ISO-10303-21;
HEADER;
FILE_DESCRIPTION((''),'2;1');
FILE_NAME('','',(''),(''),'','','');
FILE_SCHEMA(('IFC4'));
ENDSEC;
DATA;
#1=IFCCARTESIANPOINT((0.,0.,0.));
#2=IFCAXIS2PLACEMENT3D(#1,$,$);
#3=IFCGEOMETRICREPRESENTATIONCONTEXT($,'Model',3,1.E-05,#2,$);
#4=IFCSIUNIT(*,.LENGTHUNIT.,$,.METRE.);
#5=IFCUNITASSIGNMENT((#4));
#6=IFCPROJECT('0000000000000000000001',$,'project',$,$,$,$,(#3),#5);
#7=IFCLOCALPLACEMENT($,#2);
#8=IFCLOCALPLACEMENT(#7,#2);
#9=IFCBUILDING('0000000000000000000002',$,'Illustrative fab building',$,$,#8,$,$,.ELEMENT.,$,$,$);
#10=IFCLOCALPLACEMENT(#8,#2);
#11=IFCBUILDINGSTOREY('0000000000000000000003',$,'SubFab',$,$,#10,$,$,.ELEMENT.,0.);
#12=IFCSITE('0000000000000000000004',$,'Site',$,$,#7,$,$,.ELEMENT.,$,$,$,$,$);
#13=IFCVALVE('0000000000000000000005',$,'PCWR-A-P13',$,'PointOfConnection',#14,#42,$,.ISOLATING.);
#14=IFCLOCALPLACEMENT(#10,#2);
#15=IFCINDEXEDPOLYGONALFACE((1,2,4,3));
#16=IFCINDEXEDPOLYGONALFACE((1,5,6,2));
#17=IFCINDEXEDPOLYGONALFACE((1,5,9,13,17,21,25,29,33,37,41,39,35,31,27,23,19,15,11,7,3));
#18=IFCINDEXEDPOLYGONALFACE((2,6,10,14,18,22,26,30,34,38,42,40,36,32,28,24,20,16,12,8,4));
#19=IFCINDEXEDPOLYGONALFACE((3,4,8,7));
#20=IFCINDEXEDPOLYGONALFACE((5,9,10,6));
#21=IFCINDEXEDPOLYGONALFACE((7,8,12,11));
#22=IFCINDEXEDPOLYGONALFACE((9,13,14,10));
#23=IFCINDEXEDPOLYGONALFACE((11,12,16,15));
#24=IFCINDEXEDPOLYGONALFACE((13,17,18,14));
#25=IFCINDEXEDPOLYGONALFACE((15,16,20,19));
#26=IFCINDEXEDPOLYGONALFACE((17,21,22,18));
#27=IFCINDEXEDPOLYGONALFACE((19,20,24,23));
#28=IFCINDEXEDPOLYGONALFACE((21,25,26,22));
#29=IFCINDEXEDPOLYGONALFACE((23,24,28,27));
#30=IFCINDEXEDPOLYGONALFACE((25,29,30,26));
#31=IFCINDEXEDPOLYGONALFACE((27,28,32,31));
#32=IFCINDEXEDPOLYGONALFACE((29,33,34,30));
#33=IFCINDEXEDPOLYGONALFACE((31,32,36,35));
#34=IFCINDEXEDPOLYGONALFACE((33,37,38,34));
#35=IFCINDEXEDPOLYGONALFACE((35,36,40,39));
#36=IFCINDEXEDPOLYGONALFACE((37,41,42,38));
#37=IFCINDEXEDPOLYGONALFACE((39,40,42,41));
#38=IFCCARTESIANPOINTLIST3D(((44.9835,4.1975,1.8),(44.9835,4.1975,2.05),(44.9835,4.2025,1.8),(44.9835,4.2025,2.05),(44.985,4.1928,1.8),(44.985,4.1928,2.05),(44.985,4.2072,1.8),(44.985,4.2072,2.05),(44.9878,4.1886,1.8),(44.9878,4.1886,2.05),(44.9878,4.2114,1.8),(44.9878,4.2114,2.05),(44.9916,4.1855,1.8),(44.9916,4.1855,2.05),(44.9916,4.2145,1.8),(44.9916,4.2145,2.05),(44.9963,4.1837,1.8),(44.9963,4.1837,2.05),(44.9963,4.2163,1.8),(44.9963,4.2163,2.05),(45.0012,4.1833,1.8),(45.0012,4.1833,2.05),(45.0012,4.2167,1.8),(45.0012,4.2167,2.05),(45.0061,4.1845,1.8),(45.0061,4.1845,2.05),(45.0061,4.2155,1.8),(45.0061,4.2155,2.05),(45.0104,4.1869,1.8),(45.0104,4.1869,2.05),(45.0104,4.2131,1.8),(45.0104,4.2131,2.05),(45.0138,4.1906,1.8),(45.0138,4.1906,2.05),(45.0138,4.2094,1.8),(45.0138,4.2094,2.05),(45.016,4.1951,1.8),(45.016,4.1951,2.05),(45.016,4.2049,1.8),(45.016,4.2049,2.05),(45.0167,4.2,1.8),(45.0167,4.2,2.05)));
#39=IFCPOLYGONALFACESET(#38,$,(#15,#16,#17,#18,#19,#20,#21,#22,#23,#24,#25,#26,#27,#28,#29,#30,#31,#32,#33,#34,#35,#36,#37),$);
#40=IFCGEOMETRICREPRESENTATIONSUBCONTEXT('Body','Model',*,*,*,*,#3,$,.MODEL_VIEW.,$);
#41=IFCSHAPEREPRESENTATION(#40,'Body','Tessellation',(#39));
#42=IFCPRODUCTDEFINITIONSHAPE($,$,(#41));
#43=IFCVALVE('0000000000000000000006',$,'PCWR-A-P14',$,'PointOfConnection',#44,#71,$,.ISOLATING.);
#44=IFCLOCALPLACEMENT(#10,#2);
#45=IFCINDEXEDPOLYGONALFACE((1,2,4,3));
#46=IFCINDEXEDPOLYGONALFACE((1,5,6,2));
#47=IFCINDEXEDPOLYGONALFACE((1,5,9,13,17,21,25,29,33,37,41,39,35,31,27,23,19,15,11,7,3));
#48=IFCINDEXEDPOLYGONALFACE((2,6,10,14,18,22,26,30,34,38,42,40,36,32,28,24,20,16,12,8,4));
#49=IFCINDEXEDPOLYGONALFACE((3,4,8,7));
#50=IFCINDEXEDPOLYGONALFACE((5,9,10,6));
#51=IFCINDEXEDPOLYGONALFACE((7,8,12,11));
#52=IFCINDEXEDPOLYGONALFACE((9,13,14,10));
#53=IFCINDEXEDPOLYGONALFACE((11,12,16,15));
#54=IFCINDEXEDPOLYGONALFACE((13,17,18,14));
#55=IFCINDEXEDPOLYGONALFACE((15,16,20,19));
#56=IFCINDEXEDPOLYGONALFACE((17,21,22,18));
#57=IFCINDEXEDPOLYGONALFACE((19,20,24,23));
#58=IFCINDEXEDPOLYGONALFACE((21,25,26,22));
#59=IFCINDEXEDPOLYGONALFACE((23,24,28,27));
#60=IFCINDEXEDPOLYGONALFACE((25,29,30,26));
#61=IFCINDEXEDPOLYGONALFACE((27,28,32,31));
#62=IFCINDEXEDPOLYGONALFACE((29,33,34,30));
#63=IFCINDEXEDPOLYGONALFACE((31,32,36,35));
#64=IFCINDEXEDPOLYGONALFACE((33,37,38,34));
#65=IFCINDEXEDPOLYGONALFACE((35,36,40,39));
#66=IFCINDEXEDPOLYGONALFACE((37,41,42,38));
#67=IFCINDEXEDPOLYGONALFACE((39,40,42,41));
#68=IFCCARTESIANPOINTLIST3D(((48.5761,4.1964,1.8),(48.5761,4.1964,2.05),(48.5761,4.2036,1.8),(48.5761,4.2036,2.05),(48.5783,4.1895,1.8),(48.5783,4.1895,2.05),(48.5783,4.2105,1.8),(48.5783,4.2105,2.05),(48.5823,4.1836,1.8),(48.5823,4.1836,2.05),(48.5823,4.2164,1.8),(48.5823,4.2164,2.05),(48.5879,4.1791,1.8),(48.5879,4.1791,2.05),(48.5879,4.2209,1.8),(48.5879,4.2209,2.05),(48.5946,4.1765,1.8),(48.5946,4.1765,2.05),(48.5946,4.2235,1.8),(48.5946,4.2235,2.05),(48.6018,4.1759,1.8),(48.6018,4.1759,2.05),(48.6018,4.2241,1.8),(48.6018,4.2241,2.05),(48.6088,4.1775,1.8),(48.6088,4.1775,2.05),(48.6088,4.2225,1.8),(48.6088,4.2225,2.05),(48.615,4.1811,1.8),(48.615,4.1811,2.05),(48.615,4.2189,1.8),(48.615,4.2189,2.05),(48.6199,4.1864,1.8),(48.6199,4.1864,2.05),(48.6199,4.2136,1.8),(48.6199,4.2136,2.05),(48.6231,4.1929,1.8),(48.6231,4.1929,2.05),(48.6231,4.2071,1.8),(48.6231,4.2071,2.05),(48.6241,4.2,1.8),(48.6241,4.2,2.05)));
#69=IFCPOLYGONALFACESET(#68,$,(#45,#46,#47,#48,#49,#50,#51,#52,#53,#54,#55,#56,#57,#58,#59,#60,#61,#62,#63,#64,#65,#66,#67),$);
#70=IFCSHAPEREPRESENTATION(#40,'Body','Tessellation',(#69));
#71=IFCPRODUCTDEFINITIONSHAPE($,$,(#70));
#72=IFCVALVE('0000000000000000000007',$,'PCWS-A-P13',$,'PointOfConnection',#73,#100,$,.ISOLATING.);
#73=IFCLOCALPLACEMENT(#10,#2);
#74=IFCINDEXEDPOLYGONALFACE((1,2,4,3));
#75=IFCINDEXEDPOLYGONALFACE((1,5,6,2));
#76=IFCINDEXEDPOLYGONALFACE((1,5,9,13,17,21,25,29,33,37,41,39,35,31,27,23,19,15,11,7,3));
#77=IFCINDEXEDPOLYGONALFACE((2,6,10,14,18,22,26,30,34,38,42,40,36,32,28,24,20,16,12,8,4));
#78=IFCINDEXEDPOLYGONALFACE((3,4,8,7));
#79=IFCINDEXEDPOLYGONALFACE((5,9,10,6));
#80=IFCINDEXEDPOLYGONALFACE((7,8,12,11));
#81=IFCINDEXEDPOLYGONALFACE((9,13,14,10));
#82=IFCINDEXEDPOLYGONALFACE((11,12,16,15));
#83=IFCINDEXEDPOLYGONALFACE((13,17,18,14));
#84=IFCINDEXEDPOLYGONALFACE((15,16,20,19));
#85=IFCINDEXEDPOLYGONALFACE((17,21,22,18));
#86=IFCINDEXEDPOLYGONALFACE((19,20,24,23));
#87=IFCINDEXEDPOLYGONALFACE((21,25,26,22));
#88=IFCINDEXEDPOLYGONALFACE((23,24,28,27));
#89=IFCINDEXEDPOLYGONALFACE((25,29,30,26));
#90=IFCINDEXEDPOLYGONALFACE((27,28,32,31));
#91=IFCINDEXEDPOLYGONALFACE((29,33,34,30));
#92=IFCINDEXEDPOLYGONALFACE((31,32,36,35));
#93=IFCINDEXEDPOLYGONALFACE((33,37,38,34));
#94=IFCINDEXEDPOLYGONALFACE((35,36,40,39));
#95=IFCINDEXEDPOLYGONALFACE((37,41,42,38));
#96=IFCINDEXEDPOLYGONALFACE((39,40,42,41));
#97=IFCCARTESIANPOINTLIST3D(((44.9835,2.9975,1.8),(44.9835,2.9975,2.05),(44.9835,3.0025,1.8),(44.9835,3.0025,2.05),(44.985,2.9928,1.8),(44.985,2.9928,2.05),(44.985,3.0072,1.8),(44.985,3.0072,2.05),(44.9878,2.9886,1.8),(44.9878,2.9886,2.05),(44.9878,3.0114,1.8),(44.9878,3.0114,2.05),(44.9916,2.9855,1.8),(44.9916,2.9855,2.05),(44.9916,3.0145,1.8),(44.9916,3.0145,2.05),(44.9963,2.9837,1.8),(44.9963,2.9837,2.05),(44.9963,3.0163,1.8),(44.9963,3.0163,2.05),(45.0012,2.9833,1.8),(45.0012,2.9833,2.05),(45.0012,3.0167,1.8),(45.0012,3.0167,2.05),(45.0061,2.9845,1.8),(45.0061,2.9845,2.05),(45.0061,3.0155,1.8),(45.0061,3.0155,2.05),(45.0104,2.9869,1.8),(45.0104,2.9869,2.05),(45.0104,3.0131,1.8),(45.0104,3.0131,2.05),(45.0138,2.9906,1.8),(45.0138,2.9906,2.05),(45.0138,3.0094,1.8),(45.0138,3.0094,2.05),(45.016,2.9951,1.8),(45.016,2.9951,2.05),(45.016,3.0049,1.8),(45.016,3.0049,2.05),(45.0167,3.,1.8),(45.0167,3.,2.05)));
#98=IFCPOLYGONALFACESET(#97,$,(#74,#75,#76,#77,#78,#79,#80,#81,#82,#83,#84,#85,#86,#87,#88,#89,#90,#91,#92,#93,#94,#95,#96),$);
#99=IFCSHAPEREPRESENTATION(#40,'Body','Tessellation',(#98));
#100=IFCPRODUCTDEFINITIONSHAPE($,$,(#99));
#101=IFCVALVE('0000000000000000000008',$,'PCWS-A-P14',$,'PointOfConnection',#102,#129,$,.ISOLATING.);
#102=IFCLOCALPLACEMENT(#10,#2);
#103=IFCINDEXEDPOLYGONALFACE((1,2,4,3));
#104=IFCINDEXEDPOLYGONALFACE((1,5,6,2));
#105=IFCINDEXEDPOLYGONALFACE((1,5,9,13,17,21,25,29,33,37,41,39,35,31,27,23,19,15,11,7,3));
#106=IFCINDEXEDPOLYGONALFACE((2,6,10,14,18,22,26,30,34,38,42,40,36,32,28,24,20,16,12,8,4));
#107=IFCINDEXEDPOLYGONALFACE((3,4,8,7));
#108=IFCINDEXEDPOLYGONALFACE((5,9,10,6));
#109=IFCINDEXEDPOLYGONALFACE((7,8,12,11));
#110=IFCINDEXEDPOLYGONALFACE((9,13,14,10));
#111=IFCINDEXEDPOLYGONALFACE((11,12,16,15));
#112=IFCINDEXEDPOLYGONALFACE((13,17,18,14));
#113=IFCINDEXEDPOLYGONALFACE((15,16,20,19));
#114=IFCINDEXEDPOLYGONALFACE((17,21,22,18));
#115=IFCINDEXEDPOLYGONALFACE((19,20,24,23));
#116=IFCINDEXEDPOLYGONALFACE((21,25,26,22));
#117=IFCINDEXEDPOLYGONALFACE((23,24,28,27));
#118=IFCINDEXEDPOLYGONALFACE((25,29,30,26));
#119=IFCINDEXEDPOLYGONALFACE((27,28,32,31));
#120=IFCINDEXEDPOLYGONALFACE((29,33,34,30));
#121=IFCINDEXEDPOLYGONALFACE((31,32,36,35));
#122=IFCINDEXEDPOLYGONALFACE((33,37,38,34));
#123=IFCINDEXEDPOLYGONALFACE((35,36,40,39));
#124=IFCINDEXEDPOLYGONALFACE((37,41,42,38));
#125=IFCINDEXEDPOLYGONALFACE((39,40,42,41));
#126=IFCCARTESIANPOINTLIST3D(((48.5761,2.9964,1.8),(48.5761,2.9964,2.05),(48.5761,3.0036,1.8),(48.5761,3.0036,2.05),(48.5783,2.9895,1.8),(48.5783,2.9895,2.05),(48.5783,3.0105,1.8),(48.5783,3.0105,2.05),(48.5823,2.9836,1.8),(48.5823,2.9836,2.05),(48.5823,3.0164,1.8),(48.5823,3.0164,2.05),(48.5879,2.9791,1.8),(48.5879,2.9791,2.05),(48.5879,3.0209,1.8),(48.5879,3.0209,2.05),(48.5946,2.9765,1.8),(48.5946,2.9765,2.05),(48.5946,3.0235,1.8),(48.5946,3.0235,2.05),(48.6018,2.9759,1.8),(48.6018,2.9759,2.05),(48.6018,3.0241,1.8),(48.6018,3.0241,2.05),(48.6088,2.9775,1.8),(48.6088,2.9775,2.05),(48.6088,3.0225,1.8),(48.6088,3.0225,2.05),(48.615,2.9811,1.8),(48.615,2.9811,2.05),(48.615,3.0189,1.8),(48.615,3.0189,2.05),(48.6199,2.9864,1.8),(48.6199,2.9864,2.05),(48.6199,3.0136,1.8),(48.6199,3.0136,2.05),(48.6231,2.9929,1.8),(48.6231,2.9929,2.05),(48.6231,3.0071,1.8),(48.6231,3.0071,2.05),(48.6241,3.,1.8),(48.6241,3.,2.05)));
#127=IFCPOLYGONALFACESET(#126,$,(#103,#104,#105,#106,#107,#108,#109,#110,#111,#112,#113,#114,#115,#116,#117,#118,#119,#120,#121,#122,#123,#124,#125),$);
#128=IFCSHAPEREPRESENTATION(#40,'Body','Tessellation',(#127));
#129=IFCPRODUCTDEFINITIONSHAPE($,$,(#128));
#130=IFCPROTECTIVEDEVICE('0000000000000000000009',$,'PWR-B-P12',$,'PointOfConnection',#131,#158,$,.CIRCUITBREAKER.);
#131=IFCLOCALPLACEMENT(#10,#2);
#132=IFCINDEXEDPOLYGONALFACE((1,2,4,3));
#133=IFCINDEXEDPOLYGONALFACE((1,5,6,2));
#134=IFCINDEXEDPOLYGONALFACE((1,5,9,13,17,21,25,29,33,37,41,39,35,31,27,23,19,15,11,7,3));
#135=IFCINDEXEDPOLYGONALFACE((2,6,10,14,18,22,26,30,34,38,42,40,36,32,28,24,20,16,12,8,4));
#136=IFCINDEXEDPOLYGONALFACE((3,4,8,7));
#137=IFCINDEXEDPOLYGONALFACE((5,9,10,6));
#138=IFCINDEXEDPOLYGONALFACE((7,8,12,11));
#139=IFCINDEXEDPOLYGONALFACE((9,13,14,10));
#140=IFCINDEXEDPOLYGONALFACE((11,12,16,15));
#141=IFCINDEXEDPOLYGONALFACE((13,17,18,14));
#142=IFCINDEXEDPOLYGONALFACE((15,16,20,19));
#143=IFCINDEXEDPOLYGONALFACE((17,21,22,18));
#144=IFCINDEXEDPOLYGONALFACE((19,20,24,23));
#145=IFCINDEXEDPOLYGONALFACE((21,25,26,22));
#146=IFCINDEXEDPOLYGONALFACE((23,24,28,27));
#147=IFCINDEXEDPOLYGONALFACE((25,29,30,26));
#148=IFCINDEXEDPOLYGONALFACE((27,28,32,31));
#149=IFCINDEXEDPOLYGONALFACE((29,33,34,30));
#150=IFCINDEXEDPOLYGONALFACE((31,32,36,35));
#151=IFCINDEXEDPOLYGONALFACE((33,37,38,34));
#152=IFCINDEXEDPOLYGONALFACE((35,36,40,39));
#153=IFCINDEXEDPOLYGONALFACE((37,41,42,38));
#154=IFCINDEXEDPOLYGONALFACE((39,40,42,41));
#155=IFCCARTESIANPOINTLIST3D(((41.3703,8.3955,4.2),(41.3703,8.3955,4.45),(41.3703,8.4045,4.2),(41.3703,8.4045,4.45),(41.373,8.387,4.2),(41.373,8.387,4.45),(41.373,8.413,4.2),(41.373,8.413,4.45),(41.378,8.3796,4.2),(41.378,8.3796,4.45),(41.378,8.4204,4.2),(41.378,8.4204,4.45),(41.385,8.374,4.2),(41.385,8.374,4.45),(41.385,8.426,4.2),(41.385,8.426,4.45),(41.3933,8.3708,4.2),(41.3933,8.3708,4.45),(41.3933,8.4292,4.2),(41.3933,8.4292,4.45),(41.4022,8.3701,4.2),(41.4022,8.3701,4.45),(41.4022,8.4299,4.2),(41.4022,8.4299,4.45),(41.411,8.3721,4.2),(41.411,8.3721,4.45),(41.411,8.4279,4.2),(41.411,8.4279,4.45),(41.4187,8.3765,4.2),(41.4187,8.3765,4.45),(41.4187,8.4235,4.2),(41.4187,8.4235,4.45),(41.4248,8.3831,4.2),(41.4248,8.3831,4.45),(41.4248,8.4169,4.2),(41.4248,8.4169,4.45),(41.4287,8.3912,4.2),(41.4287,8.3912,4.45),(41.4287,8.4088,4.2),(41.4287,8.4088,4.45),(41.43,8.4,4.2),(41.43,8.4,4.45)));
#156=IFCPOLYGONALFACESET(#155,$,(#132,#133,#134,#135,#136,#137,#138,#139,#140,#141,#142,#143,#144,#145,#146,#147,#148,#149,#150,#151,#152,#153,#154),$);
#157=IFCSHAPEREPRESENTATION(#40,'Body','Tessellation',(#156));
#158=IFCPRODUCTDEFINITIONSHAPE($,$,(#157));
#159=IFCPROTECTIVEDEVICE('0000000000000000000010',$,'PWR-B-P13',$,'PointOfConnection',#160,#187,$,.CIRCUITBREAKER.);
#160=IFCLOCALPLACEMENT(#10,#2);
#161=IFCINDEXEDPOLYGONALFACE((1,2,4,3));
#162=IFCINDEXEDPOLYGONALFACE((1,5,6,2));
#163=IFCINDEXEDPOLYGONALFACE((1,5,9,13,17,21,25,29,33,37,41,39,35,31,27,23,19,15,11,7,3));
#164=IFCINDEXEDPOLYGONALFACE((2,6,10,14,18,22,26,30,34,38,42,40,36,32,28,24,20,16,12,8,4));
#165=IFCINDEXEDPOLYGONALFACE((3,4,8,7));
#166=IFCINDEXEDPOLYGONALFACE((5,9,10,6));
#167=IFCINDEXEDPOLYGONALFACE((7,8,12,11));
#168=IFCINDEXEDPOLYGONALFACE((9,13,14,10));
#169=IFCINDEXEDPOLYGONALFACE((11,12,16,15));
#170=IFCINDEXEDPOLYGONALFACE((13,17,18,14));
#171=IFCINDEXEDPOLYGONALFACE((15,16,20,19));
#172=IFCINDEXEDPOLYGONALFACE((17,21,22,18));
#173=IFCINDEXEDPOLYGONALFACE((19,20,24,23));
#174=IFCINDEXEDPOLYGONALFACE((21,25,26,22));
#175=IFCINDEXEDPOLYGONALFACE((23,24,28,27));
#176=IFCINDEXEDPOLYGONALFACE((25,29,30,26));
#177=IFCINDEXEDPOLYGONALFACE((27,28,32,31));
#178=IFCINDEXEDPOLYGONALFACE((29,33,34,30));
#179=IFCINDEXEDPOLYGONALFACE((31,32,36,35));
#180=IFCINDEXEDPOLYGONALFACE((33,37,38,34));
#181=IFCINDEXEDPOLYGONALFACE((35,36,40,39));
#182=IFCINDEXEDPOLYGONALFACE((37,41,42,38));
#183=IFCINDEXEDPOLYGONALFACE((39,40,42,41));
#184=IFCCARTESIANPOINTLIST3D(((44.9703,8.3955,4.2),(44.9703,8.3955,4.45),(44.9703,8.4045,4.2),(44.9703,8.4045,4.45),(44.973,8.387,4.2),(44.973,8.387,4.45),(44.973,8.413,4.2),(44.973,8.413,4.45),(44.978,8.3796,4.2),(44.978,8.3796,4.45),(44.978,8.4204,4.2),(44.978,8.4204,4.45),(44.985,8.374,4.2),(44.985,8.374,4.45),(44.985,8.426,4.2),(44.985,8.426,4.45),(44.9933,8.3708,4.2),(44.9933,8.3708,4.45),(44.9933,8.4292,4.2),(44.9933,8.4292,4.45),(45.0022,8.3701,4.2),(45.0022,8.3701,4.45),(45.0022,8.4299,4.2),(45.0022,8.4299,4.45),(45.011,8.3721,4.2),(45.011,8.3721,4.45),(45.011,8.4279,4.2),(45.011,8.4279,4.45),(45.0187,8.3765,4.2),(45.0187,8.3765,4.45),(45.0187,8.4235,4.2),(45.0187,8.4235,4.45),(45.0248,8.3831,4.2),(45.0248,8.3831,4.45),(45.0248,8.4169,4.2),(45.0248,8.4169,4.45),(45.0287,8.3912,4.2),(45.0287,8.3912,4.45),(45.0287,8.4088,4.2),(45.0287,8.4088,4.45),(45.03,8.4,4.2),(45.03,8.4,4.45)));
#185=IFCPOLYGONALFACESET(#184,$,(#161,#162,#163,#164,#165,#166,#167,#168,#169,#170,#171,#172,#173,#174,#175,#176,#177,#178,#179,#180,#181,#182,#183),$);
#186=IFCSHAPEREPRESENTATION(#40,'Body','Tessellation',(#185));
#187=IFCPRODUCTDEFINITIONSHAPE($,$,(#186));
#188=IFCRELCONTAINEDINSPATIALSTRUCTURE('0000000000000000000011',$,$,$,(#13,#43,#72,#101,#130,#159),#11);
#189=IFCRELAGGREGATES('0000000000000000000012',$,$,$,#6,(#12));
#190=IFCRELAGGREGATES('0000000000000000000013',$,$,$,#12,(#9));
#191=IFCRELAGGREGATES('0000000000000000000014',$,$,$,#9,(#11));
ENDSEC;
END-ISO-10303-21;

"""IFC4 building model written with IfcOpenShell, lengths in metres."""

from ifc_helpers import new_model, entity, si_unit, frame, origin, place, context, subcontext, project, spatial, element, save


model = new_model("IFC4")

# Units and contexts
model_context = context("Model", 3, precision=1e-05, world=origin())
body_context = subcontext(model_context, "Body", "Model", "MODEL_VIEW")
ifc_project = project(units=[si_unit("LENGTHUNIT", "METRE")], contexts=[model_context])

# Site, building, storey
site_placement = place(None, origin())
site = spatial("IfcSite", under=ifc_project, at=site_placement, Name="Site", CompositionType="ELEMENT")
building_placement = place(site_placement, origin())
building = spatial("IfcBuilding", under=site, at=building_placement, Name="Illustrative fab building", CompositionType="ELEMENT")
storey_placement = place(building_placement, origin())
storey = spatial("IfcBuildingStorey", under=building, at=storey_placement, Name="SubFab", CompositionType="ELEMENT", Elevation=0.0)

# Valves
valve_1_placement = place(storey_placement, frame((45.0, 4.2, 1.8)))
element("IfcValve", 1, at=valve_1_placement, inside=storey, Name="PCWR-A-P13", ObjectType="PointOfConnection", PredefinedType="ISOLATING", context=body_context, shape_type="AdvancedSweptSolid", body=[
    entity("IfcSweptDiskSolid", entity("IfcPolyline", [entity("IfcCartesianPoint", [0.0, 0.0, 0.0]), entity("IfcCartesianPoint", [0.0, 0.0, 0.25])]), 0.0167),
])
valve_2_placement = place(storey_placement, frame((48.6, 4.2, 1.8)))
element("IfcValve", 2, at=valve_2_placement, inside=storey, Name="PCWR-A-P14", ObjectType="PointOfConnection", PredefinedType="ISOLATING", context=body_context, shape_type="AdvancedSweptSolid", body=[
    entity("IfcSweptDiskSolid", entity("IfcPolyline", [entity("IfcCartesianPoint", [0.0, 0.0, 0.0]), entity("IfcCartesianPoint", [0.0, 0.0, 0.25])]), 0.0241),
])
valve_3_placement = place(storey_placement, frame((45.0, 3.0, 1.8)))
element("IfcValve", 3, at=valve_3_placement, inside=storey, Name="PCWS-A-P13", ObjectType="PointOfConnection", PredefinedType="ISOLATING", context=body_context, shape_type="AdvancedSweptSolid", body=[
    entity("IfcSweptDiskSolid", entity("IfcPolyline", [entity("IfcCartesianPoint", [0.0, 0.0, 0.0]), entity("IfcCartesianPoint", [0.0, 0.0, 0.25])]), 0.0167),
])
valve_4_placement = place(storey_placement, frame((48.6, 3.0, 1.8)))
element("IfcValve", 4, at=valve_4_placement, inside=storey, Name="PCWS-A-P14", ObjectType="PointOfConnection", PredefinedType="ISOLATING", context=body_context, shape_type="AdvancedSweptSolid", body=[
    entity("IfcSweptDiskSolid", entity("IfcPolyline", [entity("IfcCartesianPoint", [0.0, 0.0, 0.0]), entity("IfcCartesianPoint", [0.0, 0.0, 0.25])]), 0.0241),
])

# Protective devices
for number, where, name in (
    (5, (41.4, 8.4, 4.2), "PWR-B-P12"),
    (6, (45.0, 8.4, 4.2), "PWR-B-P13"),
):
    element("IfcProtectiveDevice", number, at=place(storey_placement, frame(where)), inside=storey, Name=name, ObjectType="PointOfConnection", PredefinedType="CIRCUITBREAKER", context=body_context, shape_type="AdvancedSweptSolid", body=[
        entity("IfcSweptDiskSolid", entity("IfcPolyline", [entity("IfcCartesianPoint", [0.0, 0.0, 0.0]), entity("IfcCartesianPoint", [0.0, 0.0, 0.25])]), 0.03),
    ])

save(model, "model.ifc")
